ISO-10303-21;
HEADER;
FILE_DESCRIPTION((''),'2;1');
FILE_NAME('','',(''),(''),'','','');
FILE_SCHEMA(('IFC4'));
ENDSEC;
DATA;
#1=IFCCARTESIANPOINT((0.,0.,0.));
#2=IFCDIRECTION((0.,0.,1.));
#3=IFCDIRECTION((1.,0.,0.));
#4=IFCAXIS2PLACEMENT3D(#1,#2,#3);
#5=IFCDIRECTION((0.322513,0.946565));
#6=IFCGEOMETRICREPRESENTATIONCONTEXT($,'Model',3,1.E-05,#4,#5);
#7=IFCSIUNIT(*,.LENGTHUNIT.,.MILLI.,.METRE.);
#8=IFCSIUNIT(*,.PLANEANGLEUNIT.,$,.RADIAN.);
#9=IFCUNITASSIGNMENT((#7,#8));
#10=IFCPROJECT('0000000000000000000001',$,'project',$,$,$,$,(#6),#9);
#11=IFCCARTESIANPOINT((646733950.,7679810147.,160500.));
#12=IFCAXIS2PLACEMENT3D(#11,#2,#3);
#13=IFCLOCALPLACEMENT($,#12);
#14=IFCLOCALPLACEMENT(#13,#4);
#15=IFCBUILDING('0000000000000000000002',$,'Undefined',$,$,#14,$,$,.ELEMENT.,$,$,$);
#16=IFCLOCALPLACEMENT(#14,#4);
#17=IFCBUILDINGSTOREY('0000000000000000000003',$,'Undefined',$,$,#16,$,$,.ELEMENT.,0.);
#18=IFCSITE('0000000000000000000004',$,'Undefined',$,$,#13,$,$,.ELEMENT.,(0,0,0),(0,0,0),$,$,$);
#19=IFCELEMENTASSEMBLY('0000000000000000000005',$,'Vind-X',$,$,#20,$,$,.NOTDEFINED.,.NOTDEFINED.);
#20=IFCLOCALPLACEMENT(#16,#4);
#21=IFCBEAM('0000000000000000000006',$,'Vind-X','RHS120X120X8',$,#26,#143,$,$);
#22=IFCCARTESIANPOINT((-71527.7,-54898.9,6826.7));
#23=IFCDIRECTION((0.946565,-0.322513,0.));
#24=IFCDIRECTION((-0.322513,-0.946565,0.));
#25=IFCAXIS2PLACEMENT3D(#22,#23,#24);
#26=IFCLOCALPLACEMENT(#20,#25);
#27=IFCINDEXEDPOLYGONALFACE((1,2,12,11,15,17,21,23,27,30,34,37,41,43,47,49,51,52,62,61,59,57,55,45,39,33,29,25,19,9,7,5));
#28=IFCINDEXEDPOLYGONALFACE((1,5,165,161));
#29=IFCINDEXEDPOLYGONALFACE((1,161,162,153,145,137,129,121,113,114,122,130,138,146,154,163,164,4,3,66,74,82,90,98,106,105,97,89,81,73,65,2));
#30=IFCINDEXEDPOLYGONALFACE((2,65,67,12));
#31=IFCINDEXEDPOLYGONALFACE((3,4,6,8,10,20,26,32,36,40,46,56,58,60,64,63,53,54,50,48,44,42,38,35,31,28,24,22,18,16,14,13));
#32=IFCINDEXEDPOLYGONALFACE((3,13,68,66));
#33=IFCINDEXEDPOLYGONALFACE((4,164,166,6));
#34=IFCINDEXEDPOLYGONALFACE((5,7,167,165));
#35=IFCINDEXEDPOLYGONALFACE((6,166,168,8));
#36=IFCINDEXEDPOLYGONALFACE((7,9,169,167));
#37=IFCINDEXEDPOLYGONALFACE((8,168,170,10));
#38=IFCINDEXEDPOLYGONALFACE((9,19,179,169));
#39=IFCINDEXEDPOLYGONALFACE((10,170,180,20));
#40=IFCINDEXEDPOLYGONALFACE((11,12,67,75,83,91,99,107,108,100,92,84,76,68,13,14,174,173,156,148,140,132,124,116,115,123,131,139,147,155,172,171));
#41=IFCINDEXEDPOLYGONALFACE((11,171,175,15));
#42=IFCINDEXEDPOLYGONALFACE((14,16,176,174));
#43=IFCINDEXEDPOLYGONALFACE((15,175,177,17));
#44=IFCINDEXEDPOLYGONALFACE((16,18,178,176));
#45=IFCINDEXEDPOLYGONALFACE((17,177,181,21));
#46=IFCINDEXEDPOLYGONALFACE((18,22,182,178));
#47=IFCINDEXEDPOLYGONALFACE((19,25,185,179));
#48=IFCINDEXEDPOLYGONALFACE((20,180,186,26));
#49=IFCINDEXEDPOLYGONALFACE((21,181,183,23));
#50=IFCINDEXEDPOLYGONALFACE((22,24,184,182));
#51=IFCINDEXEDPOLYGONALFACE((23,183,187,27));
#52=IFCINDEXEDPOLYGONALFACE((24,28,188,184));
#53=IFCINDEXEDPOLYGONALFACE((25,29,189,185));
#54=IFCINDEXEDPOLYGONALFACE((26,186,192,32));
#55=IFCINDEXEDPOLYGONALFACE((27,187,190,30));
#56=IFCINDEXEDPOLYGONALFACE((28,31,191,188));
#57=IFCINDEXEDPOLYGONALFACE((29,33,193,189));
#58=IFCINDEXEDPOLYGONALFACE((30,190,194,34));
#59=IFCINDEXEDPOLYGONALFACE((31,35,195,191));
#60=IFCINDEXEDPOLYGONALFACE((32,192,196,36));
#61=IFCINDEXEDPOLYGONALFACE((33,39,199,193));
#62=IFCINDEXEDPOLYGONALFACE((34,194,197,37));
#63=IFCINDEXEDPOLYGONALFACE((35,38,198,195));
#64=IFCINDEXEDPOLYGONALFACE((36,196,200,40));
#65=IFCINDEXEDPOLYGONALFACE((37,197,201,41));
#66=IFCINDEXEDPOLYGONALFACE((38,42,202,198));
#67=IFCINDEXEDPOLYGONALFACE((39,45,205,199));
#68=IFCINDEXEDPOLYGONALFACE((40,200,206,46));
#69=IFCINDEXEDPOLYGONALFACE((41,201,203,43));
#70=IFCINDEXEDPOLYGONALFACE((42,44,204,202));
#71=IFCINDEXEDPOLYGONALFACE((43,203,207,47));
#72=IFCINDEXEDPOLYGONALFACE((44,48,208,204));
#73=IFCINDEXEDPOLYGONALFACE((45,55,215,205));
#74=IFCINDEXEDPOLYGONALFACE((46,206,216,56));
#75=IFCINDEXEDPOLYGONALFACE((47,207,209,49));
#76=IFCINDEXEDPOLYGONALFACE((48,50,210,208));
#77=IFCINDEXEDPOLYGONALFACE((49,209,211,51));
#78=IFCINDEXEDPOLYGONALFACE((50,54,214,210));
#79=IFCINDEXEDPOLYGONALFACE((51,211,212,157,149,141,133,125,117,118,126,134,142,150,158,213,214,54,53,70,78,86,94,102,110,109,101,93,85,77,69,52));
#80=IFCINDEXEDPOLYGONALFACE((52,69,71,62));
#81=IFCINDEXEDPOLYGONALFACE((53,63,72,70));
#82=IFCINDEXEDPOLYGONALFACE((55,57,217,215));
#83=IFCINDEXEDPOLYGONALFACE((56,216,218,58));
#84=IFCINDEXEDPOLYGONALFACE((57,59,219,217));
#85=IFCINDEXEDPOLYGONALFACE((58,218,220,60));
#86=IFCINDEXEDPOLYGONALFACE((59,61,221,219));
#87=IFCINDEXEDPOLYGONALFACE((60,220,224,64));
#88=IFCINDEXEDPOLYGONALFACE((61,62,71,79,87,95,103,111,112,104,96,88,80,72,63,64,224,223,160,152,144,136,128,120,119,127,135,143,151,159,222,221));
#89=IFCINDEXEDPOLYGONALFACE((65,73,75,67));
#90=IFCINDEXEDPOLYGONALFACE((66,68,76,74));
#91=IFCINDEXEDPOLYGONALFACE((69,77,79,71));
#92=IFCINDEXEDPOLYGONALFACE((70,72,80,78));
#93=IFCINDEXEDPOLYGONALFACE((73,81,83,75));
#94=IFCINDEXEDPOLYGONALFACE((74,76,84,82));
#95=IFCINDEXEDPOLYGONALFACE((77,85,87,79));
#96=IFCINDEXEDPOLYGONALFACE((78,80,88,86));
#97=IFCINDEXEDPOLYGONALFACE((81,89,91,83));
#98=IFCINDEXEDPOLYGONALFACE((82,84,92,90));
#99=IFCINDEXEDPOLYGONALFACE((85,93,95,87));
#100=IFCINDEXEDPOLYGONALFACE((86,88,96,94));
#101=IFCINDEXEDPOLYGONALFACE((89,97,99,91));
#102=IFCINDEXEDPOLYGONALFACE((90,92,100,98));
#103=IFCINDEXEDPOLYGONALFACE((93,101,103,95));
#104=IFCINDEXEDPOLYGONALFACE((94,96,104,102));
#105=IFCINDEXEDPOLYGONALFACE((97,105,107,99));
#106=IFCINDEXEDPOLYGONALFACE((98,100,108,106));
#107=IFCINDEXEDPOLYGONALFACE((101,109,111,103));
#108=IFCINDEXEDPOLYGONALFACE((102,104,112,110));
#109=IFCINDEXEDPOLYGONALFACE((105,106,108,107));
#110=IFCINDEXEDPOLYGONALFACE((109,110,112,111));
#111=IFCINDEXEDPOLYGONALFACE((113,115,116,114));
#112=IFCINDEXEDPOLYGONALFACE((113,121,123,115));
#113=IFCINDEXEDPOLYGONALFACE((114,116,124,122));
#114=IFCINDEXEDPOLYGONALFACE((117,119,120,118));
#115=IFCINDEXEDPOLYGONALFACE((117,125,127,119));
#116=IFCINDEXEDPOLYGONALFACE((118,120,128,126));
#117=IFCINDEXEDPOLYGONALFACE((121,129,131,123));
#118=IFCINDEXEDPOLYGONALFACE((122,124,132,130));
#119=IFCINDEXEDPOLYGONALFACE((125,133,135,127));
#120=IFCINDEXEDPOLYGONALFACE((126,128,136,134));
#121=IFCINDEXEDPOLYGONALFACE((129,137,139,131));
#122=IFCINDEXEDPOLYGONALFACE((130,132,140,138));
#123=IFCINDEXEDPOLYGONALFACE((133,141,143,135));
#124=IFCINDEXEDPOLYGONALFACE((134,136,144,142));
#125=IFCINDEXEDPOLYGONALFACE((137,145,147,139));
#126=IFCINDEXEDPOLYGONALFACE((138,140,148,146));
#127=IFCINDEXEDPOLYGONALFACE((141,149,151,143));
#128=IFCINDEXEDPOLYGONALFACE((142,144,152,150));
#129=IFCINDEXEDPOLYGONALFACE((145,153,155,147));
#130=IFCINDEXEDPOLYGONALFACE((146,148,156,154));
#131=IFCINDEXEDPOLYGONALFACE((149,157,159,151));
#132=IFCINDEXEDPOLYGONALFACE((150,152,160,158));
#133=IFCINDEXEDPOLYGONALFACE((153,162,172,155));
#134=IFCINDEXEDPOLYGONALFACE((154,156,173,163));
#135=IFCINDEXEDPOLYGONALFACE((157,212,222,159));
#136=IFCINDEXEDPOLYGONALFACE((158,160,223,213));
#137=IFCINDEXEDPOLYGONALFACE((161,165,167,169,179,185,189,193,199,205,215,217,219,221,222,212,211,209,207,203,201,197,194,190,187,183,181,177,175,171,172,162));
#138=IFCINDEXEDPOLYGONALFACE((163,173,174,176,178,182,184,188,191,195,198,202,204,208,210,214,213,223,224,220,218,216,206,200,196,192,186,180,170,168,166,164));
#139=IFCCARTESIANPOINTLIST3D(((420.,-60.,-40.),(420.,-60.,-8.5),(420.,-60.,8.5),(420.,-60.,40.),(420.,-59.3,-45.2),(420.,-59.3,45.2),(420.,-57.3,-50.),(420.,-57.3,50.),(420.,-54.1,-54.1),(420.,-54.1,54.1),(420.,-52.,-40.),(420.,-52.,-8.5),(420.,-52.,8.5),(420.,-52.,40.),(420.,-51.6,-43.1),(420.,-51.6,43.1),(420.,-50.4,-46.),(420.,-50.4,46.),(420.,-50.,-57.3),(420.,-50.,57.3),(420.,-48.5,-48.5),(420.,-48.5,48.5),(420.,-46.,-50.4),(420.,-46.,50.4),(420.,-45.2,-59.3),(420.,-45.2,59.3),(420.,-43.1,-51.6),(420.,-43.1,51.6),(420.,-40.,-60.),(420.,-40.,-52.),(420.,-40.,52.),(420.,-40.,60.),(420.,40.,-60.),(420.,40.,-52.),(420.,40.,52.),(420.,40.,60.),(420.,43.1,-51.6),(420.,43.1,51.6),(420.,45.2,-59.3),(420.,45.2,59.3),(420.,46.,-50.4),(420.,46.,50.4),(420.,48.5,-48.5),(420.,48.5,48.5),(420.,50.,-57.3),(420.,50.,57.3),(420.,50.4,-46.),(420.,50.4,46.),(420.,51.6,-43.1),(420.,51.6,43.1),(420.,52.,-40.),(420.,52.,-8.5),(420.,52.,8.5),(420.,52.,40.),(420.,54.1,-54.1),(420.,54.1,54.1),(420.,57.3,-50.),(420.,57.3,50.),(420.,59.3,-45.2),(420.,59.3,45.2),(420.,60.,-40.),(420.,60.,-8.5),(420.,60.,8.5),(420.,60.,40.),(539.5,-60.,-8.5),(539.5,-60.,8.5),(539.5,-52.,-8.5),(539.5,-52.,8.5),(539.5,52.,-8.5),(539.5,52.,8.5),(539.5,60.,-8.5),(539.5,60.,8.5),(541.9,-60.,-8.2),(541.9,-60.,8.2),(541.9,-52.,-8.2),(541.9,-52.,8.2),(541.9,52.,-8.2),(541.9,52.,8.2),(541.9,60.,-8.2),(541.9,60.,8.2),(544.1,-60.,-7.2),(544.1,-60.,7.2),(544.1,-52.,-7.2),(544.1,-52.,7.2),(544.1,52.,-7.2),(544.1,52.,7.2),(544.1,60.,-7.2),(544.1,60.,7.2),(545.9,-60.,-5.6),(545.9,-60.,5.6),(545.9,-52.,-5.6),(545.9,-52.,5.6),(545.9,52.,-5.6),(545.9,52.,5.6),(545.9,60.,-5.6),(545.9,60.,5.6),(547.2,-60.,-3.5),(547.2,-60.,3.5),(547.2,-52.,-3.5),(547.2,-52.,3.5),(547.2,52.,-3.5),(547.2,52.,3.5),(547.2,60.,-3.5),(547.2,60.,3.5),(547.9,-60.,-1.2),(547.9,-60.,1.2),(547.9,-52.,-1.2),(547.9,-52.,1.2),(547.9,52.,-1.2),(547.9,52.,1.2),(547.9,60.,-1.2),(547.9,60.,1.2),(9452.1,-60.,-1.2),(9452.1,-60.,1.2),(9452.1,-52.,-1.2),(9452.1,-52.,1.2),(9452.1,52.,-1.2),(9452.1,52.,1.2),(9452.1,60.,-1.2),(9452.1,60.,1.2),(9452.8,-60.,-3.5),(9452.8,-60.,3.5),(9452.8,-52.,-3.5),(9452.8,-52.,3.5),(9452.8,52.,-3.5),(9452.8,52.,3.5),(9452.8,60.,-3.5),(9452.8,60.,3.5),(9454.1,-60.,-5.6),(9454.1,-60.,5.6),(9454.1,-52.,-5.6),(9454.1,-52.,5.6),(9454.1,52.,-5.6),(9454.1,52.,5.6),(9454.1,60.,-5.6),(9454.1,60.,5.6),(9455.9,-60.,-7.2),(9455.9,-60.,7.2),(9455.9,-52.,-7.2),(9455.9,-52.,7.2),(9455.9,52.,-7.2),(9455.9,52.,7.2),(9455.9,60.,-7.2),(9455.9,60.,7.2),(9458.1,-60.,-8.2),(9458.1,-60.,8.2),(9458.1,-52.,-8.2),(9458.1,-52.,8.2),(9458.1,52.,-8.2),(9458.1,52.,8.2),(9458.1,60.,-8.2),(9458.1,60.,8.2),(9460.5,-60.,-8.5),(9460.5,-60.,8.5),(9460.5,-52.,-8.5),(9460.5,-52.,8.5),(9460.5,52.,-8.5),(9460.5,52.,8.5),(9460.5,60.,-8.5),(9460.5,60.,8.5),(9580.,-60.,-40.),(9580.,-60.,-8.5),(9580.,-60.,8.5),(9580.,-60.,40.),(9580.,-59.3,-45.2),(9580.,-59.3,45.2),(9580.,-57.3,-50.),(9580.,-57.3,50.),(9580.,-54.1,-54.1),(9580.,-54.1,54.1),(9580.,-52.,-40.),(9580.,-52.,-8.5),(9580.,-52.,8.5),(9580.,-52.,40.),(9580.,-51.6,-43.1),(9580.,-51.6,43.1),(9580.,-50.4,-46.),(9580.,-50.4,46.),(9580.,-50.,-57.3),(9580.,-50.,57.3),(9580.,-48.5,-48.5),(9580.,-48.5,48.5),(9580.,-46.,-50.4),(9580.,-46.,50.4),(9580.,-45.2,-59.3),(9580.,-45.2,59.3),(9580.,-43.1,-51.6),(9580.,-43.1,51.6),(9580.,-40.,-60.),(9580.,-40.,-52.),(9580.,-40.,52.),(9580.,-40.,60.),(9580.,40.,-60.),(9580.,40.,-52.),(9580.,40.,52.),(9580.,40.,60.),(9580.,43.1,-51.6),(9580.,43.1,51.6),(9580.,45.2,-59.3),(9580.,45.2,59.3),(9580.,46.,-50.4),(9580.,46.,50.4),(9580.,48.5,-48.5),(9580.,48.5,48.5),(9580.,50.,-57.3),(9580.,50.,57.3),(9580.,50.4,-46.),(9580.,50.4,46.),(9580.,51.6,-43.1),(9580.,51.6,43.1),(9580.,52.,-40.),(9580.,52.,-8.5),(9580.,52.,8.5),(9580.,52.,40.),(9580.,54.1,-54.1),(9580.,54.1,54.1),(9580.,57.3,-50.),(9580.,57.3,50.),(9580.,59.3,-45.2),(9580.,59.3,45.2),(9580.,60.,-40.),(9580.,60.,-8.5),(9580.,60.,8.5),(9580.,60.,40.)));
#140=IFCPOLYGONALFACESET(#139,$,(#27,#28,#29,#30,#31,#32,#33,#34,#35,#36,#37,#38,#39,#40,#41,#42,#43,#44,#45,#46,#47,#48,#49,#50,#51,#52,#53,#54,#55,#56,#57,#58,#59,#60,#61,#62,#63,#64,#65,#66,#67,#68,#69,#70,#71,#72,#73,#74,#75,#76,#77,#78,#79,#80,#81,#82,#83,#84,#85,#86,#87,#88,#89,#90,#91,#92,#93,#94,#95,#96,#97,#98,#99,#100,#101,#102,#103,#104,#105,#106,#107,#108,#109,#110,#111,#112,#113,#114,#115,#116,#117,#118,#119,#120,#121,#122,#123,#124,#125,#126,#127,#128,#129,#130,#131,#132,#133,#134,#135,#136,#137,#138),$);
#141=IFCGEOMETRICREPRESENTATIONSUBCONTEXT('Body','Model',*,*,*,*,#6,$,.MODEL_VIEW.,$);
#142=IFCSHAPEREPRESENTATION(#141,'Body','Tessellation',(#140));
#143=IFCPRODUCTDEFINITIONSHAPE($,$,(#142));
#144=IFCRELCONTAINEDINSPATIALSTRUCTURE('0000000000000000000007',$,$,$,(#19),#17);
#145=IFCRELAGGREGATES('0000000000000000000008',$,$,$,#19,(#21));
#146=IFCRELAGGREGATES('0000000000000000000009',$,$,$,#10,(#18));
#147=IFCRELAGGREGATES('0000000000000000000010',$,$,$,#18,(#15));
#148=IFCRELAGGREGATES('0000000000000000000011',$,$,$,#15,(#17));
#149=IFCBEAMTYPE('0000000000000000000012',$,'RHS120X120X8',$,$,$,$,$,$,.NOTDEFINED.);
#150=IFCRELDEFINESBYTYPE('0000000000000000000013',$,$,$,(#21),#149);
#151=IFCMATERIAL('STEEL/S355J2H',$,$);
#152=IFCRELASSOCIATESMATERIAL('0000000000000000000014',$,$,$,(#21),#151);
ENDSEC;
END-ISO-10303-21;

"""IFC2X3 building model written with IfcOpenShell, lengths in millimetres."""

from ifc_helpers import new_model, si_unit, direction, frame, frame_2d, origin_with_axes, origin_2d_with_axis, place, context, subcontext, project, spatial, polyline, circle_curve, parameter, trimmed, segment, composite_curve, hollow_rectangle, outline, extrude, boolean, halfspace, material, type_object, element, aggregate, save


model = new_model("IFC2X3")

# Units and contexts
model_context = context("Model", 3, precision=1e-05, world=origin_with_axes(), true_north=direction((0.322513, 0.946565)))
body_context = subcontext(model_context, "Body", "Model", "MODEL_VIEW")
ifc_project = project(units=[si_unit("LENGTHUNIT", "METRE", prefix="MILLI"), si_unit("PLANEANGLEUNIT", "RADIAN")], contexts=[model_context])

# Site, building, storey
site_placement = place(None, frame((646733950.0, 7679810147.0, 160500.0), z_axis=(0.0, 0.0, 1.0), x_axis=(1.0, 0.0, 0.0)))
site = spatial("IfcSite", under=ifc_project, at=site_placement, Name="Undefined", CompositionType="ELEMENT", RefLatitude=(0, 0, 0), RefLongitude=(0, 0, 0))
building_placement = place(site_placement, origin_with_axes())
building = spatial("IfcBuilding", under=site, at=building_placement, Name="Undefined", CompositionType="ELEMENT")
storey_placement = place(building_placement, origin_with_axes())
storey = spatial("IfcBuildingStorey", under=building, at=storey_placement, Name="Undefined", CompositionType="ELEMENT", Elevation=0.0)

# Shared definitions
ifc_material_1 = material(Name="STEEL/S355J2H")

# Element assembly, beam
assembly_1_placement = place(storey_placement, origin_with_axes())
assembly_1 = element("IfcElementAssembly", 1, at=assembly_1_placement, inside=storey, Name="Vind-X", AssemblyPlace="NOTDEFINED", PredefinedType="NOTDEFINED")
beam_type_1 = type_object("IfcBeamType", Name="RHS120X120X8", PredefinedType="NOTDEFINED")
beam_1_placement = place(assembly_1_placement, frame((-71527.7, -54898.9, 6826.7), z_axis=(0.946565, -0.322513, 0.0), x_axis=(-0.322513, -0.946565, 0.0)))
beam_1 = element("IfcBeam", 2, at=beam_1_placement, type_object=beam_type_1, material=ifc_material_1, Name="Vind-X", Description="RHS120X120X8", context=body_context, shape_type="CSG", body=[
    boolean("DIFFERENCE", boolean("DIFFERENCE", boolean("DIFFERENCE", boolean("DIFFERENCE", extrude(hollow_rectangle(XDim=120.0, YDim=120.0, WallThickness=8.0, InnerFilletRadius=12.0, OuterFilletRadius=20.0, at=origin_2d_with_axis()), frame((10000.0, 0.0, 0.0), z_axis=(-1.0, 0.0, 0.0), x_axis=(0.0, -1.0, 0.0)), (0.0, 0.0, 1.0), 10000.0), extrude(outline(composite_curve([segment(trimmed(circle_curve(frame_2d((8.5, 8.5), x_axis=(-1.0, 0.0)), 8.5), [parameter(0.0)], [parameter(1.570796)], True, "PARAMETER"), True, "CONTINUOUS"), segment(polyline([(8.5, 0.0), (133.0, 0.0), (133.0, 17.0), (8.5, 17.0)]), True, "CONTINUOUS"), segment(trimmed(circle_curve(frame_2d((8.5, 8.5), x_axis=(0.0, 1.0)), 8.5), [parameter(0.0)], [parameter(1.570796)], True, "PARAMETER"), True, "CONTINUOUS"), segment(polyline([(0.0, 8.5), (0.0, 8.5)]), True, "CONTINUOUS")], self_intersect=True)), frame((548.0, 62.2, 8.5), z_axis=(0.0, -1.0, 0.0), x_axis=(-1.0, 0.0, 0.0)), (0.0, 0.0, 1.0), 124.5)), extrude(outline(composite_curve([segment(trimmed(circle_curve(frame_2d((8.5, 8.5), x_axis=(-1.0, 0.0)), 8.5), [parameter(0.0)], [parameter(1.570796)], True, "PARAMETER"), True, "CONTINUOUS"), segment(polyline([(8.5, 0.0), (133.0, 0.0), (133.0, 17.0), (8.5, 17.0)]), True, "CONTINUOUS"), segment(trimmed(circle_curve(frame_2d((8.5, 8.5), x_axis=(0.0, 1.0)), 8.5), [parameter(0.0)], [parameter(1.570796)], True, "PARAMETER"), True, "CONTINUOUS"), segment(polyline([(0.0, 8.5), (0.0, 8.5)]), True, "CONTINUOUS")], self_intersect=True)), frame((9452.0, -62.2, 8.5), z_axis=(0.0, 1.0, 0.0), x_axis=(1.0, 0.0, 0.0)), (0.0, 0.0, 1.0), 124.5)), halfspace(frame((9580.0, 0.0, -1000.0), z_axis=(-1.0, 0.0, 0.0), x_axis=(0.0, 1.0, 0.0)), True)), halfspace(frame((420.0, 0.0, -1000.0), z_axis=(1.0, 0.0, 0.0), x_axis=(0.0, -1.0, 0.0)), True)),
])

aggregate(assembly_1, [beam_1])

save(model, "model.ifc")
